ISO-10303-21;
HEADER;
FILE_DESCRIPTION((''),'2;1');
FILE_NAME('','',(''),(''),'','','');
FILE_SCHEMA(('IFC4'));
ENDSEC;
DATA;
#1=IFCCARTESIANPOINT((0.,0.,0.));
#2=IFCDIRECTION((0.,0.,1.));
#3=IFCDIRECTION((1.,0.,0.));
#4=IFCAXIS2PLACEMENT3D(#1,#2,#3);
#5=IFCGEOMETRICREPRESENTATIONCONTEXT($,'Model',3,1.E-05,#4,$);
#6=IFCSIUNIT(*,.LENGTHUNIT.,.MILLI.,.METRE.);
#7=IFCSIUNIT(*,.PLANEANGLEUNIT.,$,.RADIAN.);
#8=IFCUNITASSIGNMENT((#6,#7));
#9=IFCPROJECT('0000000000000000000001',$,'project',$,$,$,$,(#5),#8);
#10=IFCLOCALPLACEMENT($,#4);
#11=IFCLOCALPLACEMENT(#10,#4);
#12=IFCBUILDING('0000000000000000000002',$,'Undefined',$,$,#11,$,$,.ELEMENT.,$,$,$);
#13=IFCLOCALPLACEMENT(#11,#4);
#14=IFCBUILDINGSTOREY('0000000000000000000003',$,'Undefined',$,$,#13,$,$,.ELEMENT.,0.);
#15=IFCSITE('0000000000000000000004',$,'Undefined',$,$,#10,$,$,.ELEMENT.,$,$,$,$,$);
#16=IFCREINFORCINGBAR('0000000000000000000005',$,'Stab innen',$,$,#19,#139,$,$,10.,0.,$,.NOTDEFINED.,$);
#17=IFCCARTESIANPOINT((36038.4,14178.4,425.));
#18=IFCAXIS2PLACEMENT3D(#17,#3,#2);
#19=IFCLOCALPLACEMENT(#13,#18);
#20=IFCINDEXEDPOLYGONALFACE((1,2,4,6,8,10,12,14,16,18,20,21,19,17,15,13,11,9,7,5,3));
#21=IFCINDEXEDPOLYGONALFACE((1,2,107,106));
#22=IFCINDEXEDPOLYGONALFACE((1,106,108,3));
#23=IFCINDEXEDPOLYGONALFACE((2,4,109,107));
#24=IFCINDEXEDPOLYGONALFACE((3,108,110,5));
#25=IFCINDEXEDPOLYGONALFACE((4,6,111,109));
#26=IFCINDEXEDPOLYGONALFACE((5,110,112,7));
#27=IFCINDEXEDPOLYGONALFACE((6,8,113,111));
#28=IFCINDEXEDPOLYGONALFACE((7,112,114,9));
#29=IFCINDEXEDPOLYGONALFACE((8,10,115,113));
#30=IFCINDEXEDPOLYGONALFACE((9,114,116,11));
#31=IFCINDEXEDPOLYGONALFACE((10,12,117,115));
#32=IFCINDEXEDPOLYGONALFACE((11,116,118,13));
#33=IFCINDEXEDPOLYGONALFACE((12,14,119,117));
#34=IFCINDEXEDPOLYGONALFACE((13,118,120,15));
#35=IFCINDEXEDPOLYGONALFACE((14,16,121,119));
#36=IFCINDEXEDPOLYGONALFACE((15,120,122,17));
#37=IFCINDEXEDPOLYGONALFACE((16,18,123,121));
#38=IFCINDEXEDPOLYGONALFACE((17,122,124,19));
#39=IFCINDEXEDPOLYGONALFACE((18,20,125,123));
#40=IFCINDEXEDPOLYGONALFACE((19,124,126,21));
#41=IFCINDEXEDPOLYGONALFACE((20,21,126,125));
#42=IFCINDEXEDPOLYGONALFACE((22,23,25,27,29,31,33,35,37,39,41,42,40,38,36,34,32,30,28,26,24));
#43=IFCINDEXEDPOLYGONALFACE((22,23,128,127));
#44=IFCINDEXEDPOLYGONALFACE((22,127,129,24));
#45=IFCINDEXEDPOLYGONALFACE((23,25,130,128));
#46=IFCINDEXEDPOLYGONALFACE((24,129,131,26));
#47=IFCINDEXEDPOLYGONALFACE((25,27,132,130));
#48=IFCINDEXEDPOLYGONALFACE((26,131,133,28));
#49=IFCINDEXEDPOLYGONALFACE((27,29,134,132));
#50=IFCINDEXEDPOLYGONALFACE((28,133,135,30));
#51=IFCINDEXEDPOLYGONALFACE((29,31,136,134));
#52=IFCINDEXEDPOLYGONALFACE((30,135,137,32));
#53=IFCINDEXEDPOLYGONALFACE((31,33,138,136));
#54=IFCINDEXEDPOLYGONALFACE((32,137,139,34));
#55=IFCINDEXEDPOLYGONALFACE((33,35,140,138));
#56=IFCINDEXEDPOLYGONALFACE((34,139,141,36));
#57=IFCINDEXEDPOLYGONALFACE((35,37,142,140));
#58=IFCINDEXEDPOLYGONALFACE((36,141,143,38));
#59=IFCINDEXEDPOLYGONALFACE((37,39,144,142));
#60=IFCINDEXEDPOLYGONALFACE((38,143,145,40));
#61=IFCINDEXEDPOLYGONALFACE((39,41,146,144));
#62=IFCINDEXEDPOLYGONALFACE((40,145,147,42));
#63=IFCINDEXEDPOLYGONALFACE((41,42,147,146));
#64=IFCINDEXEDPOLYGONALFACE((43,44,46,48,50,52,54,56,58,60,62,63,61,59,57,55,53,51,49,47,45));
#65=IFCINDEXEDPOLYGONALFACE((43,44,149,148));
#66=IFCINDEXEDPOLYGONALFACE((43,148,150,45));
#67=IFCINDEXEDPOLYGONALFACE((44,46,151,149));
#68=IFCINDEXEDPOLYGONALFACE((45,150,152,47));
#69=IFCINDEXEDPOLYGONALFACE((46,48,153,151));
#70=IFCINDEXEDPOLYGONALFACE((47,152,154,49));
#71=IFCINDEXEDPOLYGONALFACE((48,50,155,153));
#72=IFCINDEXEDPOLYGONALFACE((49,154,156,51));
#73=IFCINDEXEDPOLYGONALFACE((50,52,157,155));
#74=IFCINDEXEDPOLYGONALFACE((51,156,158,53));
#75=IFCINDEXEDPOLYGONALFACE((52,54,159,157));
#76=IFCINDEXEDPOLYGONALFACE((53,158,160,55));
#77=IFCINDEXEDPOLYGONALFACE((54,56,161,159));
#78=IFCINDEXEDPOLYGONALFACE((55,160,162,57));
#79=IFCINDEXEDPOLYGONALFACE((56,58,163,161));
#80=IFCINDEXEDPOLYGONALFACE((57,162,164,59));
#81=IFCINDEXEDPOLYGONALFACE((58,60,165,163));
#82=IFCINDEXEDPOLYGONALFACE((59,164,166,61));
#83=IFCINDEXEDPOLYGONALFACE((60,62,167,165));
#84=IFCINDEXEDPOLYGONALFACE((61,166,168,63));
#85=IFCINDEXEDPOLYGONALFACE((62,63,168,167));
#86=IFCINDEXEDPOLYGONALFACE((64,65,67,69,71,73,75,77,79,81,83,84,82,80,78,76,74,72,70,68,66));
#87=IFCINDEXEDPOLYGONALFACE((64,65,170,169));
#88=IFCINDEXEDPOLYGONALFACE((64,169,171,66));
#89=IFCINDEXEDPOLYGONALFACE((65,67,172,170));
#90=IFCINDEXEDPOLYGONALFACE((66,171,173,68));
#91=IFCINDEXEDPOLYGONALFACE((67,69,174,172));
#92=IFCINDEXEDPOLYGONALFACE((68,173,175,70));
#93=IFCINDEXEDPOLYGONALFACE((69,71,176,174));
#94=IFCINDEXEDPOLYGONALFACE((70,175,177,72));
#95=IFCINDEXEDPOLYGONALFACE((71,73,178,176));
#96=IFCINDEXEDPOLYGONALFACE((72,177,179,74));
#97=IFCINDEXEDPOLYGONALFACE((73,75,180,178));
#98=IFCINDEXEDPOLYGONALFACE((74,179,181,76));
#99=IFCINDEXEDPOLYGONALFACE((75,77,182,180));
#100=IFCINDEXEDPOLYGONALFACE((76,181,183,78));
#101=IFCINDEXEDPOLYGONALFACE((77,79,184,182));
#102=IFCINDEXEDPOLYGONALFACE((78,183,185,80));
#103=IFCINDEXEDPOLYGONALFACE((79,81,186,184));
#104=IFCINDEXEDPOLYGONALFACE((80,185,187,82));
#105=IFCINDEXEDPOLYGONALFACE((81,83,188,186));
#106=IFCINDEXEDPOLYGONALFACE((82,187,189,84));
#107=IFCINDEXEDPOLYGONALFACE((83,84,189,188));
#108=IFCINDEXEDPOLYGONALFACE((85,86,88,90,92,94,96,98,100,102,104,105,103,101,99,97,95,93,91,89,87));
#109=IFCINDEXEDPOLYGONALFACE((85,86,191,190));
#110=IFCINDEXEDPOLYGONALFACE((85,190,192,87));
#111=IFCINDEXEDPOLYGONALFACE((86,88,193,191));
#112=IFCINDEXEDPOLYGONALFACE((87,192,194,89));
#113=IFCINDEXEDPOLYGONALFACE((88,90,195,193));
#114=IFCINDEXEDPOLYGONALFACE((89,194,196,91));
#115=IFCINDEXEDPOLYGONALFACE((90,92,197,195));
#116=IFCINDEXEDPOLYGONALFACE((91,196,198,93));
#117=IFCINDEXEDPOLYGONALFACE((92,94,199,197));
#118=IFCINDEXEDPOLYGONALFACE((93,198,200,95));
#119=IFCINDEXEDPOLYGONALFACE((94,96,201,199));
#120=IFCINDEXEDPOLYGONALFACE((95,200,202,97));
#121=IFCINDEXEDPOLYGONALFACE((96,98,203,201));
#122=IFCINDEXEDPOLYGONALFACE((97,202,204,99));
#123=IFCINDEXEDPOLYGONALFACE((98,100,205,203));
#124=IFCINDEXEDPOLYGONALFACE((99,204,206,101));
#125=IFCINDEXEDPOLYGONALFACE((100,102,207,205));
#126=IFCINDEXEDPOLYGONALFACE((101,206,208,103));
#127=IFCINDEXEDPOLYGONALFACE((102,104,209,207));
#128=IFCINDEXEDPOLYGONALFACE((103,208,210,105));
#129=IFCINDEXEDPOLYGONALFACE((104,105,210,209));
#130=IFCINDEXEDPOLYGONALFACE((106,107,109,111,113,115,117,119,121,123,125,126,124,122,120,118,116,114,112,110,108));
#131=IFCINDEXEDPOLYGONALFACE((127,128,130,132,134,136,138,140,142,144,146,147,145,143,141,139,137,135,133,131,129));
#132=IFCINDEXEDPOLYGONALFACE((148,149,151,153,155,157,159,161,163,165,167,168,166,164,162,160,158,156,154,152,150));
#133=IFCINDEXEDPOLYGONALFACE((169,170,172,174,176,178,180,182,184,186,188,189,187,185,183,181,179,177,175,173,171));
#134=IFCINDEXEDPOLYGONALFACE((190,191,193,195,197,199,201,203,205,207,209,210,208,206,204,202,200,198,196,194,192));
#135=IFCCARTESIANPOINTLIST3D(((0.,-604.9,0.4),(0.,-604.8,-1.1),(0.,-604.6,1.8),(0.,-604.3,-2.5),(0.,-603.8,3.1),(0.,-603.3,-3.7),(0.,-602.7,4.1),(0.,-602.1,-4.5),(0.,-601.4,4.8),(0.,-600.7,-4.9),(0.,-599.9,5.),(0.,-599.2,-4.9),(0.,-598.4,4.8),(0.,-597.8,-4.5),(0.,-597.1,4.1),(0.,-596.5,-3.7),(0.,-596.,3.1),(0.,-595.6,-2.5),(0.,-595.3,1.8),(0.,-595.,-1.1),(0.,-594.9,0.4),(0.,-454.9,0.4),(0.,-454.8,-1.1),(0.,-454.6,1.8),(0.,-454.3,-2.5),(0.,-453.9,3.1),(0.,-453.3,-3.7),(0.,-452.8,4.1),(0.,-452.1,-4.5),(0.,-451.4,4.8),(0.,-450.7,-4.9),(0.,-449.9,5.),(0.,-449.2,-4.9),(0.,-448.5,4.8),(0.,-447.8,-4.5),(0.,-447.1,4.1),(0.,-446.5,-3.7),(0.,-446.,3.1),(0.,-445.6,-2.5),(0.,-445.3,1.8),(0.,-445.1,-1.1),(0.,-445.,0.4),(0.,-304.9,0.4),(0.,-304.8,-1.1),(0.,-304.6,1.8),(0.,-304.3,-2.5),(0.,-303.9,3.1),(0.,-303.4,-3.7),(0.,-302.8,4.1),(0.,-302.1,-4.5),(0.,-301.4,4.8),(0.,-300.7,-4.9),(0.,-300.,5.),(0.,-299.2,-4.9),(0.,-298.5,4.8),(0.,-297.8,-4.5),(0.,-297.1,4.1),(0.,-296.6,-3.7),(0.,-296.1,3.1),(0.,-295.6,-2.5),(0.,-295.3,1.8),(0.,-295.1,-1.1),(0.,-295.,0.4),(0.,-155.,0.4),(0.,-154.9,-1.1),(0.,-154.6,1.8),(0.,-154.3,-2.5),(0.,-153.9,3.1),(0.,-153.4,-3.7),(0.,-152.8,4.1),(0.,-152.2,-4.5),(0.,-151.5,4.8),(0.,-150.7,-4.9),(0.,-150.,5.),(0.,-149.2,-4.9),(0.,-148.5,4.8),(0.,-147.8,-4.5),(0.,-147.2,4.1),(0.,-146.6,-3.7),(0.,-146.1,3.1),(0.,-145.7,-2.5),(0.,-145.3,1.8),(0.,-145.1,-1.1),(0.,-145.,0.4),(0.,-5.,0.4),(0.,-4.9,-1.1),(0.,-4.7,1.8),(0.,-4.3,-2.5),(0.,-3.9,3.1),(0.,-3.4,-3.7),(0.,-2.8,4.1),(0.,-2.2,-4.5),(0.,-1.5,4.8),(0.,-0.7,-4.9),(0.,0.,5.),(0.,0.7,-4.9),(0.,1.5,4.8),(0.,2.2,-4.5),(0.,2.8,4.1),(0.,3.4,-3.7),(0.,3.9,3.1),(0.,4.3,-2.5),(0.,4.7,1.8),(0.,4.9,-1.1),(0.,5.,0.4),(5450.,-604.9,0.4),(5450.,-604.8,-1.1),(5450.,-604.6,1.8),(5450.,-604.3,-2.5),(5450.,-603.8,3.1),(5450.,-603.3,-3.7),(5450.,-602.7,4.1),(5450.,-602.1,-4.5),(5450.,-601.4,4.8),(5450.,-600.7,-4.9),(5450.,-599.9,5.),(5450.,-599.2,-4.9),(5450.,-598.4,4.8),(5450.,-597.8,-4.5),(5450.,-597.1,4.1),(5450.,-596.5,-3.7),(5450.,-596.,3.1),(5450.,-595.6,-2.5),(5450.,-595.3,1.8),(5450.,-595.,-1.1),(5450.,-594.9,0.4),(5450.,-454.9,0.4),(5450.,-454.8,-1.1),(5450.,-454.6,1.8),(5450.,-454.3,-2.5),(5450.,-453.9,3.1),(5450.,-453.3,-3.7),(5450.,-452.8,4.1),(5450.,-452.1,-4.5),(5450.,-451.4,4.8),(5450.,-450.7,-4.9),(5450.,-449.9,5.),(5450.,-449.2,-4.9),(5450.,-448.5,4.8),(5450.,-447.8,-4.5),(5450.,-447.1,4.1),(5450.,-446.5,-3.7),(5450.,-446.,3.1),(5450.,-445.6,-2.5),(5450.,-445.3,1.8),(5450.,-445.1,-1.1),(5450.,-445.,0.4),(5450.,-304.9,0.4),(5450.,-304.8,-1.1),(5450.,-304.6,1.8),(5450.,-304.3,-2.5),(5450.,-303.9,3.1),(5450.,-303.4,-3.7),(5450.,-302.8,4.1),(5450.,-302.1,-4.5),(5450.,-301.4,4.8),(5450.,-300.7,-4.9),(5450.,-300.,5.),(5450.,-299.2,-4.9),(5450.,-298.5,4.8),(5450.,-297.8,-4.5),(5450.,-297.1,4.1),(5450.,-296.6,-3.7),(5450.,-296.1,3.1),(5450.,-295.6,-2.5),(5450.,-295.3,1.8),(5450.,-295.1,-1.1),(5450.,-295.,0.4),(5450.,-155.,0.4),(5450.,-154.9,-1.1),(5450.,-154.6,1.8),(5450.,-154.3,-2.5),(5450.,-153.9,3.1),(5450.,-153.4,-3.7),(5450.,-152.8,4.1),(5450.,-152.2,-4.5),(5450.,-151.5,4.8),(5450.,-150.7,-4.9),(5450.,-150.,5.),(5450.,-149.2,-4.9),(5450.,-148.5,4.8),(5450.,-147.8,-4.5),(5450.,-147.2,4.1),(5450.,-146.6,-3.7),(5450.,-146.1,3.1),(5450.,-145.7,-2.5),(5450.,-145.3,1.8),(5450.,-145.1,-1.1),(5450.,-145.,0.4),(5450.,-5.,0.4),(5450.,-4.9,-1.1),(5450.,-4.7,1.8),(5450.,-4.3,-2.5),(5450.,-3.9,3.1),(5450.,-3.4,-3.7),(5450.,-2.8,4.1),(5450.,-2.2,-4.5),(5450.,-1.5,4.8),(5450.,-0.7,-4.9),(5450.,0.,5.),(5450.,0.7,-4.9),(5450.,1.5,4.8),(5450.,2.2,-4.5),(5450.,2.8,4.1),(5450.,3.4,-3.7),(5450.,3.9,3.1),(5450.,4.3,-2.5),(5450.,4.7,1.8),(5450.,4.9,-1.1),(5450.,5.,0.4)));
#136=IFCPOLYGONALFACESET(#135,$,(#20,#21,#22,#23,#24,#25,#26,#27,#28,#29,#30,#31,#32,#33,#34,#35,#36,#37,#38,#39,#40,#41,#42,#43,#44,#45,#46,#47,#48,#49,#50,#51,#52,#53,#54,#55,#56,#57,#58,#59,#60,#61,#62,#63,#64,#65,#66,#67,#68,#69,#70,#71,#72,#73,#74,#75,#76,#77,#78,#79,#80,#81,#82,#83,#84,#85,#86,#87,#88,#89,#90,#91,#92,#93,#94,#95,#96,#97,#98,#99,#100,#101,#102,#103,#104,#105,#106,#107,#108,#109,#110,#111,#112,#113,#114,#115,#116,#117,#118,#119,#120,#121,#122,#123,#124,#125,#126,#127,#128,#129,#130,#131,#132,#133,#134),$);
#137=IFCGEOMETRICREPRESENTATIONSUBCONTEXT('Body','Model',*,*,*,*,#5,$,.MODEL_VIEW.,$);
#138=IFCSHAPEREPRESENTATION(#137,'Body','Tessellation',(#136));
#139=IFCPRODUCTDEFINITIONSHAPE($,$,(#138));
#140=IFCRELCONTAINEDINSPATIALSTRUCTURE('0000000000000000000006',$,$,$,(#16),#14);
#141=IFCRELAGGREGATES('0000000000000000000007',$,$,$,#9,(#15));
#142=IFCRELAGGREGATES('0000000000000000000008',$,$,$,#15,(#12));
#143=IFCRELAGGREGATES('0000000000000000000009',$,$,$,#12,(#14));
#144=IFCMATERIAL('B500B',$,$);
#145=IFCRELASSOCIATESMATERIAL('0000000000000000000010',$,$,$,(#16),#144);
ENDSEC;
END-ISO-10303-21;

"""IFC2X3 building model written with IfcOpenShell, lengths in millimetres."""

from ifc_helpers import new_model, entity, si_unit, frame, origin_with_axes, place, context, subcontext, project, spatial, source, transform, mapped, material, element, save


model = new_model("IFC2X3")

# Units and contexts
model_context = context("Model", 3, precision=1e-05, world=origin_with_axes())
body_context = subcontext(model_context, "Body", "Model", "MODEL_VIEW")
ifc_project = project(units=[si_unit("LENGTHUNIT", "METRE", prefix="MILLI"), si_unit("PLANEANGLEUNIT", "RADIAN")], contexts=[model_context])

# Site, building, storey
site_placement = place(None, origin_with_axes())
site = spatial("IfcSite", under=ifc_project, at=site_placement, Name="Undefined", CompositionType="ELEMENT")
building_placement = place(site_placement, origin_with_axes())
building = spatial("IfcBuilding", under=site, at=building_placement, Name="Undefined", CompositionType="ELEMENT")
storey_placement = place(building_placement, origin_with_axes())
storey = spatial("IfcBuildingStorey", under=building, at=storey_placement, Name="Undefined", CompositionType="ELEMENT", Elevation=0.0)

# Reinforcing bar
ifc_material_1 = material(Name="B500B")
shared_shape_1 = source(origin_with_axes(), body_context, "Body", "AdvancedSweptSolid", [
    entity("IfcSweptDiskSolid", entity("IfcTrimmedCurve", entity("IfcLine", entity("IfcCartesianPoint", [0.0, 0.0, 0.0]), entity("IfcVector", entity("IfcDirection", [1.0, 0.0, 0.0]), 1.0)), [entity("IfcParameterValue", 0.0)], [entity("IfcParameterValue", 5450.0)], True, "PARAMETER"), 5.0, None, 0.0, 5450.0),
])
shared_shape_2 = source(origin_with_axes(), body_context, "Body", "AdvancedSweptSolid", [
    entity("IfcSweptDiskSolid", entity("IfcTrimmedCurve", entity("IfcLine", entity("IfcCartesianPoint", [0.0, 0.0, 0.0]), entity("IfcVector", entity("IfcDirection", [1.0, 0.0, 0.0]), 1.0)), [entity("IfcParameterValue", 0.0)], [entity("IfcParameterValue", 5450.0)], True, "PARAMETER"), 5.0, None, 0.0, 5450.0),
])
shared_shape_3 = source(origin_with_axes(), body_context, "Body", "AdvancedSweptSolid", [
    entity("IfcSweptDiskSolid", entity("IfcTrimmedCurve", entity("IfcLine", entity("IfcCartesianPoint", [0.0, 0.0, 0.0]), entity("IfcVector", entity("IfcDirection", [1.0, 0.0, 0.0]), 1.0)), [entity("IfcParameterValue", 0.0)], [entity("IfcParameterValue", 5450.0)], True, "PARAMETER"), 5.0, None, 0.0, 5450.0),
])
shared_shape_4 = source(origin_with_axes(), body_context, "Body", "AdvancedSweptSolid", [
    entity("IfcSweptDiskSolid", entity("IfcTrimmedCurve", entity("IfcLine", entity("IfcCartesianPoint", [0.0, 0.0, 0.0]), entity("IfcVector", entity("IfcDirection", [1.0, 0.0, 0.0]), 1.0)), [entity("IfcParameterValue", 0.0)], [entity("IfcParameterValue", 5450.0)], True, "PARAMETER"), 5.0, None, 0.0, 5450.0),
])
shared_shape_5 = source(origin_with_axes(), body_context, "Body", "AdvancedSweptSolid", [
    entity("IfcSweptDiskSolid", entity("IfcTrimmedCurve", entity("IfcLine", entity("IfcCartesianPoint", [0.0, 0.0, 0.0]), entity("IfcVector", entity("IfcDirection", [1.0, 0.0, 0.0]), 1.0)), [entity("IfcParameterValue", 0.0)], [entity("IfcParameterValue", 5450.0)], True, "PARAMETER"), 5.0, None, 0.0, 5450.0),
])
reinforcing_bar_1_placement = place(storey_placement, frame((36038.4, 14178.4, 425.0), z_axis=(1.0, 0.0, 0.0), x_axis=(0.0, 0.0, 1.0)))
element("IfcReinforcingBar", 1, at=reinforcing_bar_1_placement, inside=storey, material=ifc_material_1, Name="Stab innen", BarRole="NOTDEFINED", CrossSectionArea=0.0, NominalDiameter=10.0, context=body_context, shape_type="MappedRepresentation", body=[
    mapped(shared_shape_1, transform((0.0, 0.0, 0.0))),
    mapped(shared_shape_2, transform((0.0, -150.0, 0.0))),
    mapped(shared_shape_3, transform((0.0, -300.0, 0.0))),
    mapped(shared_shape_4, transform((0.0, -449.9, 0.0))),
    mapped(shared_shape_5, transform((0.0, -599.9, 0.0))),
])

save(model, "model.ifc")
